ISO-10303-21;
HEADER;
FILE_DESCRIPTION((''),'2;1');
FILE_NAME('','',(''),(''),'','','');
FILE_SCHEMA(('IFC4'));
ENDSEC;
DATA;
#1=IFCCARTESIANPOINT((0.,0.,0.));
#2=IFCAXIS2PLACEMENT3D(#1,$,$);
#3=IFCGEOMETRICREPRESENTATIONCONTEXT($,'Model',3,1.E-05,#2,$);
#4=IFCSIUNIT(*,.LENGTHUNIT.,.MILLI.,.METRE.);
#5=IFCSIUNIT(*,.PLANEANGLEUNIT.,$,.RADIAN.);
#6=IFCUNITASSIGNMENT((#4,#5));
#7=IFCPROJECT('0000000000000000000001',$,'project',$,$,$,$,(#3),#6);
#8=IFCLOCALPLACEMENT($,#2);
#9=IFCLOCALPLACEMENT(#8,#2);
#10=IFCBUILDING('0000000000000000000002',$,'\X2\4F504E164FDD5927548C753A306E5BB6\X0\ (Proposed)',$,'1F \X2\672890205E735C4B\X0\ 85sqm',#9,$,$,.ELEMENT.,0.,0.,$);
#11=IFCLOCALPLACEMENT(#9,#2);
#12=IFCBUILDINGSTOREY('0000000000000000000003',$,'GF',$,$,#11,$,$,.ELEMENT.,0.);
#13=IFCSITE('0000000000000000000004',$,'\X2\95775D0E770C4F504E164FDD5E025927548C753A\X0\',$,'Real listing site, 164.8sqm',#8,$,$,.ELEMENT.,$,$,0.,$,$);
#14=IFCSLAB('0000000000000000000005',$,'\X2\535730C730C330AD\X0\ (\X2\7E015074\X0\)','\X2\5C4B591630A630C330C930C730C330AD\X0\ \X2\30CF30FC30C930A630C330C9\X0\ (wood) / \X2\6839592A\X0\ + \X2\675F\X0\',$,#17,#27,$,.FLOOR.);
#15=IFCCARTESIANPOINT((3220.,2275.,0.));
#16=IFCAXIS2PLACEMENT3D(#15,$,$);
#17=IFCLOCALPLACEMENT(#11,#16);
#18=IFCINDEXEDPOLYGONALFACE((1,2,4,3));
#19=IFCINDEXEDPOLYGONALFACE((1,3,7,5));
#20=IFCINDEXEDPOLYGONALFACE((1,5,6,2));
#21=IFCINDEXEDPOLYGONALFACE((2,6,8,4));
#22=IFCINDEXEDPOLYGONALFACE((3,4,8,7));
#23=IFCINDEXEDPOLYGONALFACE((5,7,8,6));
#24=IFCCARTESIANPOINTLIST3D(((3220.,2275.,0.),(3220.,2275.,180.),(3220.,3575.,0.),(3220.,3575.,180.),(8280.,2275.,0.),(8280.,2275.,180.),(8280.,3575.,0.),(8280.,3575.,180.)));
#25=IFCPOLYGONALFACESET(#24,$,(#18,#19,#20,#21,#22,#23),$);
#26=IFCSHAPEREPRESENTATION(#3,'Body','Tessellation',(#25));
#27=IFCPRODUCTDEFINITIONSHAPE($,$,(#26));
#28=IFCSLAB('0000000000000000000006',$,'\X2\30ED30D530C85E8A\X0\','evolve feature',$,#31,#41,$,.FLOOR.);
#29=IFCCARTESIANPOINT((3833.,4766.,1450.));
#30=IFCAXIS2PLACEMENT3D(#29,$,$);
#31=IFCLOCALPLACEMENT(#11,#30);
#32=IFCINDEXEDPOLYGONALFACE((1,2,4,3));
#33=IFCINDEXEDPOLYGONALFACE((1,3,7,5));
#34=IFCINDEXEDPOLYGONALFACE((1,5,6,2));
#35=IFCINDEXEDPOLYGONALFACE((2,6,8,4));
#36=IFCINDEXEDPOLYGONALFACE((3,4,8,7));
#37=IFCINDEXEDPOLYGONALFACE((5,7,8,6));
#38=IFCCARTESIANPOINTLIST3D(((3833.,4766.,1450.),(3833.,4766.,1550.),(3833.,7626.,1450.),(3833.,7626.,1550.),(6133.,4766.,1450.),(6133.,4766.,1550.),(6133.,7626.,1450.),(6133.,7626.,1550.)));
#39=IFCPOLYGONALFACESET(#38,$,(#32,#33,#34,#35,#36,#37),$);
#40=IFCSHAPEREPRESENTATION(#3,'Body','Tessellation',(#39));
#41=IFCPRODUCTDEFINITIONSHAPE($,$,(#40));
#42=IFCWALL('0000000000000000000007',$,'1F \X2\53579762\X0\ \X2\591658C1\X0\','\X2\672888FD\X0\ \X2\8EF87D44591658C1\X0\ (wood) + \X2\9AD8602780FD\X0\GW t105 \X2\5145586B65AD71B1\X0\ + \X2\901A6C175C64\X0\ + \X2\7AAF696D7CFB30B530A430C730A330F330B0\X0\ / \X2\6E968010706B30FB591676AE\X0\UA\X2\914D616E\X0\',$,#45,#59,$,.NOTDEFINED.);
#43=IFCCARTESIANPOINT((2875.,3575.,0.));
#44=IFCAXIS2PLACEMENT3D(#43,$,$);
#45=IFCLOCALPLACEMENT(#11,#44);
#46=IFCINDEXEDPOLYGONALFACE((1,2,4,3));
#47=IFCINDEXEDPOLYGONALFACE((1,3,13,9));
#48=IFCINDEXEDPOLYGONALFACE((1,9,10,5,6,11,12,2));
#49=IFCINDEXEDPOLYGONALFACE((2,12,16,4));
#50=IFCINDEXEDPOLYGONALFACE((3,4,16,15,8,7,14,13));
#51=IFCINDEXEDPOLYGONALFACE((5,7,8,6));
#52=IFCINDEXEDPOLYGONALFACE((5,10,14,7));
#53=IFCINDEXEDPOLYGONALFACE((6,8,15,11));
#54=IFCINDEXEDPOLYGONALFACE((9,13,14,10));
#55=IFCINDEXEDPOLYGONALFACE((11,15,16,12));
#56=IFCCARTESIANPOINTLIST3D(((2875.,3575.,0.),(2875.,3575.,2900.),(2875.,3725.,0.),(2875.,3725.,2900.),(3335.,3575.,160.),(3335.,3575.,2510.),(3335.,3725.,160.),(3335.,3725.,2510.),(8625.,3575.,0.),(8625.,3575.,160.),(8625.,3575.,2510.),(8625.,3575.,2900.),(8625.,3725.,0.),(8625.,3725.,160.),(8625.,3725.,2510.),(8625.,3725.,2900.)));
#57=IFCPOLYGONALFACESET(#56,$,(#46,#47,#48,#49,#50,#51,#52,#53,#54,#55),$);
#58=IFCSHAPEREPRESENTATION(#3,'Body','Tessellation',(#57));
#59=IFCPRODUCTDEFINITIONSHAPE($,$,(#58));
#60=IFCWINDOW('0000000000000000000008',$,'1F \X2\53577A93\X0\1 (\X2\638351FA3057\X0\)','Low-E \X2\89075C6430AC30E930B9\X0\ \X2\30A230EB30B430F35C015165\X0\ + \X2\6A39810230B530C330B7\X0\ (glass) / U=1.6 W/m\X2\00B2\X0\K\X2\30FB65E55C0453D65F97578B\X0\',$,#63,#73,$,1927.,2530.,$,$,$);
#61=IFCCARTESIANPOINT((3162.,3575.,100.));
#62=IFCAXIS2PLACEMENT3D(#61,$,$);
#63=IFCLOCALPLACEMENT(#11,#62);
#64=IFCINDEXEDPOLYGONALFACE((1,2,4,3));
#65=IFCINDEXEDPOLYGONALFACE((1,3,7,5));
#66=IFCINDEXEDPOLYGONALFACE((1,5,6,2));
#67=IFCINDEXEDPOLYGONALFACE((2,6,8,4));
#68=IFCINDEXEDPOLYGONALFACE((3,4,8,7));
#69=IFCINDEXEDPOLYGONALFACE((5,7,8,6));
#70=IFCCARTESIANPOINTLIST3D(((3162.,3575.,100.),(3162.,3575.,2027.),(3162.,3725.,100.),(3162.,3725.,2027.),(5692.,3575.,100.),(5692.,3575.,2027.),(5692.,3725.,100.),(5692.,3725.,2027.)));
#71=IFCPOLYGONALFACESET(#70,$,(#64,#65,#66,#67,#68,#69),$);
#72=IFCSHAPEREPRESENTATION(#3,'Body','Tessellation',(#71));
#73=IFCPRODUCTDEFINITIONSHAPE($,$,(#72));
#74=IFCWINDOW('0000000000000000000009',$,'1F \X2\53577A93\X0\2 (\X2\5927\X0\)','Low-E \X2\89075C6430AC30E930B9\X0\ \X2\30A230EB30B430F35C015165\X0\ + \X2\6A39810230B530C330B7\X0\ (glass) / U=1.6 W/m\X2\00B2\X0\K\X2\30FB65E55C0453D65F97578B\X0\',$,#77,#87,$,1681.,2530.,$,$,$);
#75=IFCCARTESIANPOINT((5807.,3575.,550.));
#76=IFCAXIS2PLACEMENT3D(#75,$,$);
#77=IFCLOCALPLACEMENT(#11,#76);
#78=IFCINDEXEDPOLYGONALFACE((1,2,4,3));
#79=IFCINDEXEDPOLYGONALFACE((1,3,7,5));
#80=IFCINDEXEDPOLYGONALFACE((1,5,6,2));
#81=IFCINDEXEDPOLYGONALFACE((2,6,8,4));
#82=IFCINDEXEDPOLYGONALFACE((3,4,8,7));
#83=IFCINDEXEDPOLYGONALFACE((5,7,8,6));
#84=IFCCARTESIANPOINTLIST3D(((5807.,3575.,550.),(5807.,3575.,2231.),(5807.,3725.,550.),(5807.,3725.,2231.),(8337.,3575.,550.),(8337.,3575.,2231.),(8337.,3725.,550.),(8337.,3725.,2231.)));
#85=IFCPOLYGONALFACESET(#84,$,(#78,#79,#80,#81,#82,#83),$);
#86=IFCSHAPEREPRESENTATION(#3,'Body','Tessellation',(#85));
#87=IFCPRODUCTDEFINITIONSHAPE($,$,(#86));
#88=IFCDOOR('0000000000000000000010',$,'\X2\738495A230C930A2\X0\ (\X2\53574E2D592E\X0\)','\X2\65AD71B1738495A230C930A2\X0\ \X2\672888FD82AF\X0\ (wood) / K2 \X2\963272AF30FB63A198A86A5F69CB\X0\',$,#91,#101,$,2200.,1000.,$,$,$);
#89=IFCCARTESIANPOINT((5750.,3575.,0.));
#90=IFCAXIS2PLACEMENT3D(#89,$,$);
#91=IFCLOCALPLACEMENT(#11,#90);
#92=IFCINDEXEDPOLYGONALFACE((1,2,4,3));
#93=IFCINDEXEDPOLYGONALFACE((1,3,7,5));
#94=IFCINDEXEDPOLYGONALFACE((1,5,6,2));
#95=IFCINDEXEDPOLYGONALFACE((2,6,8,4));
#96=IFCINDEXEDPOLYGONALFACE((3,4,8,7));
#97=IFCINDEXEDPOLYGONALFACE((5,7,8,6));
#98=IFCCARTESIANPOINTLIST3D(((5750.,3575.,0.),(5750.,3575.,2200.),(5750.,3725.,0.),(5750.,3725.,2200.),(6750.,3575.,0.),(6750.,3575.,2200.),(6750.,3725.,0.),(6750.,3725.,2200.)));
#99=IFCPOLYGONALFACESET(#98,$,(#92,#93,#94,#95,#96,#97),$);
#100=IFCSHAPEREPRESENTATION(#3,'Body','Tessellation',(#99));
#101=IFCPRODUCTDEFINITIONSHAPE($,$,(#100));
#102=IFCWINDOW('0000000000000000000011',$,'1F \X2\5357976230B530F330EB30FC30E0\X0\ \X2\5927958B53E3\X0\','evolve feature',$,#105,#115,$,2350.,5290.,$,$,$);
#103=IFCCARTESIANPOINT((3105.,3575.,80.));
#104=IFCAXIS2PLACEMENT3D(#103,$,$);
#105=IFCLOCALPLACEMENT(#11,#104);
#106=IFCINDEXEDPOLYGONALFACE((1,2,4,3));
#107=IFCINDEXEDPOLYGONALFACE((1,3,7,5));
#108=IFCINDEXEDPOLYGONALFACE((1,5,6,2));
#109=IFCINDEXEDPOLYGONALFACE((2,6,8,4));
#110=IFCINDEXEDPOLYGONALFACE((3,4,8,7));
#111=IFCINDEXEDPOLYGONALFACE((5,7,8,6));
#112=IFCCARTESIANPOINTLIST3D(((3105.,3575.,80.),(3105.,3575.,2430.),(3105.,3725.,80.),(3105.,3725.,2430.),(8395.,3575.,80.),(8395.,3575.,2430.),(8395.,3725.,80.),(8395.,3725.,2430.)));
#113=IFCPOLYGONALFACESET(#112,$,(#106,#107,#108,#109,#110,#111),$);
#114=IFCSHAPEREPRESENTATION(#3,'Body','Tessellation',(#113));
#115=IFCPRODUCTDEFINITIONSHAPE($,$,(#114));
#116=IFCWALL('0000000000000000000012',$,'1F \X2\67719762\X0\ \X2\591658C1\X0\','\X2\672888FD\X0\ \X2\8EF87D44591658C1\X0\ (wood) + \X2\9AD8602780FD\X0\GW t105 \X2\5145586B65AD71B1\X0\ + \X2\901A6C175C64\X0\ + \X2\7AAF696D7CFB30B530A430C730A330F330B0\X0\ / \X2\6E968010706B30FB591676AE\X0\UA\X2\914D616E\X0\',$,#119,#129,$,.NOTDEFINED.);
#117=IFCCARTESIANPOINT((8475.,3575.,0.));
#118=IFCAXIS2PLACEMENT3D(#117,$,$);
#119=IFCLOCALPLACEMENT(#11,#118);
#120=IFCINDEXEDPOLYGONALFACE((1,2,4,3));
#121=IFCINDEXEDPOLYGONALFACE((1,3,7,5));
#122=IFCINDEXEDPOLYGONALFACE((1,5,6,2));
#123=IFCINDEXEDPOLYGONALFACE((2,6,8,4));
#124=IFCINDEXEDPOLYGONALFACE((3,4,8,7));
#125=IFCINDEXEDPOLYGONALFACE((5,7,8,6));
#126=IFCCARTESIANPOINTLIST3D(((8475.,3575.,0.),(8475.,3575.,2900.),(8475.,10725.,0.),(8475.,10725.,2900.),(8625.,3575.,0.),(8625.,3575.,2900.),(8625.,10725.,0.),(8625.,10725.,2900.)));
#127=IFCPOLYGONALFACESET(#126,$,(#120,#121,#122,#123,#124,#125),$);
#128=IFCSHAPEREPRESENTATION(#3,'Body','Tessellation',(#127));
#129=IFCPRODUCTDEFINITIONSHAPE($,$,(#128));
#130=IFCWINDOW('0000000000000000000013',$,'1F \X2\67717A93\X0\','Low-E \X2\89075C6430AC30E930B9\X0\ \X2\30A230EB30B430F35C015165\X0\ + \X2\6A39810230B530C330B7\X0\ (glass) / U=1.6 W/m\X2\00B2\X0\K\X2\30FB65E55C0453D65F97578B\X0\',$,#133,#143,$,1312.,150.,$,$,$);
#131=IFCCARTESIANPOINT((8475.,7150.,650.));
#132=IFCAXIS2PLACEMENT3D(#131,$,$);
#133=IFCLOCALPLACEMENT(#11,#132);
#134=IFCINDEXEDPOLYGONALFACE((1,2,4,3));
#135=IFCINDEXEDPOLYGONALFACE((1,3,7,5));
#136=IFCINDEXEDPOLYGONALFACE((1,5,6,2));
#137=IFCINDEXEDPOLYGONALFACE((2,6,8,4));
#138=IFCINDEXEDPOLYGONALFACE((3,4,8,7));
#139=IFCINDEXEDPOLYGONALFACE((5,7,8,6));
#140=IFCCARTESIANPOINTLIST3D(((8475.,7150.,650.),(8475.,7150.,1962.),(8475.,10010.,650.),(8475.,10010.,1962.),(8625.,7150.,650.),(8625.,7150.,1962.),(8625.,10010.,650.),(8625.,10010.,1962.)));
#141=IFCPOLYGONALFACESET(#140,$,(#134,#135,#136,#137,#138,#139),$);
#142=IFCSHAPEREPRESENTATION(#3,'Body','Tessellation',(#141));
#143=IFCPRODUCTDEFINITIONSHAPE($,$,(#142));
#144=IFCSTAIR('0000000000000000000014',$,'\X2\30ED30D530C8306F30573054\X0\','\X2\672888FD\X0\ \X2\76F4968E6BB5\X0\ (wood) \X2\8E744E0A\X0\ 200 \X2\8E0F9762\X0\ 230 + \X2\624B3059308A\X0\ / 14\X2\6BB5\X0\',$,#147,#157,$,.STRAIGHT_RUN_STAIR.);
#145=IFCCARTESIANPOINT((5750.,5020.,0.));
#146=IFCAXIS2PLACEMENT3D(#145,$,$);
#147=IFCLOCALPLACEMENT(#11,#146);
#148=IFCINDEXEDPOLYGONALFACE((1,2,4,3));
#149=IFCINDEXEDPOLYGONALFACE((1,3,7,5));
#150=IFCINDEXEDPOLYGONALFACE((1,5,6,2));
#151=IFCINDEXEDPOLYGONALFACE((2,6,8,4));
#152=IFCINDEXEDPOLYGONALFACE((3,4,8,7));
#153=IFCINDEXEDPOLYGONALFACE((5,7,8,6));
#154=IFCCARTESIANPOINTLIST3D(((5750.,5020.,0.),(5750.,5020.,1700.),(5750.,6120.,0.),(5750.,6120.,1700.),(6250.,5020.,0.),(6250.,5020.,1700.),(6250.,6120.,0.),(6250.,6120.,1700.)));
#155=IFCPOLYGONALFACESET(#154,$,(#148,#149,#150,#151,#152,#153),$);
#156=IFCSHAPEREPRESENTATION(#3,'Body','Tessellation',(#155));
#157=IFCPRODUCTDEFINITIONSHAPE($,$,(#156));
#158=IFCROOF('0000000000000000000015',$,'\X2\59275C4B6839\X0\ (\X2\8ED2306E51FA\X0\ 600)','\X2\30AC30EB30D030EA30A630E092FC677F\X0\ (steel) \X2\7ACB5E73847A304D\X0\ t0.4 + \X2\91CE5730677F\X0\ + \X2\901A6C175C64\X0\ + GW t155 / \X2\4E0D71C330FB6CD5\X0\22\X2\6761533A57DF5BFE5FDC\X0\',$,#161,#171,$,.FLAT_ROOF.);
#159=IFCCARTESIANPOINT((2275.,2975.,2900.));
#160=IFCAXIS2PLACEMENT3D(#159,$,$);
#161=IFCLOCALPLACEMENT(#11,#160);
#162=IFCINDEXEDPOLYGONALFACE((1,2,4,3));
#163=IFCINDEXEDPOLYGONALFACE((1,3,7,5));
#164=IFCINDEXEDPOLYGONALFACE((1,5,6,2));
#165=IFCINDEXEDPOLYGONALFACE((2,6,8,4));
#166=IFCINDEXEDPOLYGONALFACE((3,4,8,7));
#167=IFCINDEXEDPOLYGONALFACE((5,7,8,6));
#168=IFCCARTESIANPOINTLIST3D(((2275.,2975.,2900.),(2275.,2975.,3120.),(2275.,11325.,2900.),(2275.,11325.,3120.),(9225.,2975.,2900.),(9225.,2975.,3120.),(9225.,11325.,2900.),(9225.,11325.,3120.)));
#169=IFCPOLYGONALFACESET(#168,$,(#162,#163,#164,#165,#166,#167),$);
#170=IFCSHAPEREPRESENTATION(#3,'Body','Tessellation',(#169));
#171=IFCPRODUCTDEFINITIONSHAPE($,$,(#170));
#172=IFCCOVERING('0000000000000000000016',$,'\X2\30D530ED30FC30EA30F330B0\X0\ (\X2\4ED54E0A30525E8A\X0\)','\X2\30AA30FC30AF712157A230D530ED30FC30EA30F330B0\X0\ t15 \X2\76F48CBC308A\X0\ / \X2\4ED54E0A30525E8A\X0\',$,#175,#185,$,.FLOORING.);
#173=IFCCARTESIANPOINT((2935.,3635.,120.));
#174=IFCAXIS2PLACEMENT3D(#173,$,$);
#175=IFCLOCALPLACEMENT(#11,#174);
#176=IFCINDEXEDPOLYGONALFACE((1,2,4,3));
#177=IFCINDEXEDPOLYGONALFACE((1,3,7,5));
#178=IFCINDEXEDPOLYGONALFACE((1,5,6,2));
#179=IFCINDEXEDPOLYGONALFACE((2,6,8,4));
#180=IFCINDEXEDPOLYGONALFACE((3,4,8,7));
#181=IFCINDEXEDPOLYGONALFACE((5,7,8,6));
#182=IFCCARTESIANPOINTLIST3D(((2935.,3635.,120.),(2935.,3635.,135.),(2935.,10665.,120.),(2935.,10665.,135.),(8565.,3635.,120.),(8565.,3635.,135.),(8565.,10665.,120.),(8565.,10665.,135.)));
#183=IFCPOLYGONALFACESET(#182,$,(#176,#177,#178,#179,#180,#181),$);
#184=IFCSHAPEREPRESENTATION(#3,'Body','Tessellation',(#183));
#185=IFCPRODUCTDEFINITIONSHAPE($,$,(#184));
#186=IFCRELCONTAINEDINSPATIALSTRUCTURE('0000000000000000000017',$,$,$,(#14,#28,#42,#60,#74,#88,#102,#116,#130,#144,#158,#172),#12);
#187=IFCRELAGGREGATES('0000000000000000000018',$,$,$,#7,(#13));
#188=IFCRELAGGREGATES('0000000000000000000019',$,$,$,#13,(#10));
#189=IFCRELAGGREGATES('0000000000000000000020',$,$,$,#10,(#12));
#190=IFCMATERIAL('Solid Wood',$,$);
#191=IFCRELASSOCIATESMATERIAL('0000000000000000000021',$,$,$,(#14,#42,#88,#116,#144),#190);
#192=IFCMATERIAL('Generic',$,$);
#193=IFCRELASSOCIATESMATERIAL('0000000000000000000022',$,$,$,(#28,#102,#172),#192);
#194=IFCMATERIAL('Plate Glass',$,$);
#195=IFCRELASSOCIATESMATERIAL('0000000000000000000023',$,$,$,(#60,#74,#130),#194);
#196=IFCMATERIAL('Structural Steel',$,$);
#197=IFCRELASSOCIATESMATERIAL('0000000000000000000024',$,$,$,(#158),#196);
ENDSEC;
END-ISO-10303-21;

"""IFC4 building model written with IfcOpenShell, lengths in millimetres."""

from ifc_helpers import new_model, si_unit, frame, frame_2d, origin, place, context, project, spatial, rectangle, extrude, material, element, fill, save


model = new_model("IFC4")

# Units and contexts
model_context = context("Model", 3, precision=1e-05, world=origin())
ifc_project = project(units=[si_unit("LENGTHUNIT", "METRE", prefix="MILLI"), si_unit("PLANEANGLEUNIT", "RADIAN")], contexts=[model_context])

# Site, building, storey
site_placement = place(None, origin())
site = spatial("IfcSite", under=ifc_project, at=site_placement, Name="長崎県佐世保市大和町", ObjectType="Real listing site, 164.8sqm", CompositionType="ELEMENT", RefElevation=0.0)
building_placement = place(site_placement, origin())
building = spatial("IfcBuilding", under=site, at=building_placement, Name="佐世保大和町の家 (Proposed)", ObjectType="1F 木造平屋 85sqm", CompositionType="ELEMENT", ElevationOfRefHeight=0.0, ElevationOfTerrain=0.0)
storey_placement = place(building_placement, origin())
storey = spatial("IfcBuildingStorey", under=building, at=storey_placement, Name="GF", CompositionType="ELEMENT", Elevation=0.0)

# Slabs
ifc_material_1 = material(Name="Solid Wood")
slab_1_placement = place(storey_placement, frame((3220.0, 2275.0, 0.0)))
element("IfcSlab", 1, at=slab_1_placement, inside=storey, material=ifc_material_1, Name="南デッキ (縁側)", Description="屋外ウッドデッキ ハードウッド (wood) / 根太 + 束", PredefinedType="FLOOR", context=model_context, shape_type="SweptSolid", body=[
    extrude(rectangle(XDim=5060.0, YDim=1300.0, at=frame_2d((2530.0, 650.0))), frame((3220.0, 2275.0, 0.0)), (0.0, 0.0, 1.0), 180.0),
])
ifc_material_2 = material(Name="Generic")
slab_2_placement = place(storey_placement, frame((3833.0, 4766.0, 1450.0)))
element("IfcSlab", 2, at=slab_2_placement, inside=storey, material=ifc_material_2, Name="ロフト床", Description="evolve feature", PredefinedType="FLOOR", context=model_context, shape_type="SweptSolid", body=[
    extrude(rectangle(XDim=2300.0, YDim=2860.0, at=frame_2d((1150.0, 1430.0))), frame((3833.0, 4766.0, 1450.0)), (0.0, 0.0, 1.0), 100.0),
])

# Wall, openings, windows, door
wall_1_placement = place(storey_placement, frame((2875.0, 3575.0, 0.0)))
wall_1 = element("IfcWall", 3, at=wall_1_placement, inside=storey, material=ifc_material_1, Name="1F 南面 外壁", Description="木製 軸組外壁 (wood) + 高性能GW t105 充填断熱 + 通気層 + 窯業系サイディング / 準耐火・外皮UA配慮", PredefinedType="NOTDEFINED", context=model_context, shape_type="SweptSolid", body=[
    extrude(rectangle(XDim=5750.0, YDim=150.0, at=frame_2d((2875.0, 75.0))), frame((2875.0, 3575.0, 0.0)), (0.0, 0.0, 1.0), 2900.0),
])
opening_1_placement = place(storey_placement, frame((3162.0, 3575.0, 100.0)))
opening_1 = element("IfcOpeningElement", 4, at=opening_1_placement, cuts=wall_1, PredefinedType="NOTDEFINED", context=model_context, shape_type="SweptSolid", body=[
    extrude(rectangle(XDim=2530.0, YDim=150.0, at=frame_2d((1265.0, 75.0))), frame((3162.0, 3575.0, 100.0)), (0.0, 0.0, 1.0), 1927.0),
])
opening_2_placement = place(storey_placement, frame((5807.0, 3575.0, 550.0)))
opening_2 = element("IfcOpeningElement", 5, at=opening_2_placement, cuts=wall_1, PredefinedType="NOTDEFINED", context=model_context, shape_type="SweptSolid", body=[
    extrude(rectangle(XDim=2530.0, YDim=150.0, at=frame_2d((1265.0, 75.0))), frame((5807.0, 3575.0, 550.0)), (0.0, 0.0, 1.0), 1681.0),
])
opening_3_placement = place(storey_placement, frame((5750.0, 3575.0, 0.0)))
opening_3 = element("IfcOpeningElement", 6, at=opening_3_placement, cuts=wall_1, PredefinedType="NOTDEFINED", context=model_context, shape_type="SweptSolid", body=[
    extrude(rectangle(XDim=1000.0, YDim=150.0, at=frame_2d((500.0, 75.0))), frame((5750.0, 3575.0, 0.0)), (0.0, 0.0, 1.0), 2200.0),
])
opening_4_placement = place(storey_placement, frame((3105.0, 3575.0, 80.0)))
opening_4 = element("IfcOpeningElement", 7, at=opening_4_placement, cuts=wall_1, PredefinedType="NOTDEFINED", context=model_context, shape_type="SweptSolid", body=[
    extrude(rectangle(XDim=5290.0, YDim=150.0, at=frame_2d((2645.0, 75.0))), frame((3105.0, 3575.0, 80.0)), (0.0, 0.0, 1.0), 2350.0),
])
ifc_material_3 = material(Name="Plate Glass")
window_1_placement = place(storey_placement, frame((3162.0, 3575.0, 100.0)))
window_1 = element("IfcWindow", 8, at=window_1_placement, inside=storey, material=ifc_material_3, Name="1F 南窓1 (掃出し)", Description="Low-E 複層ガラス アルゴン封入 + 樹脂サッシ (glass) / U=1.6 W/m²K・日射取得型", OverallHeight=1927.0, OverallWidth=2530.0, context=model_context, shape_type="SweptSolid", body=[
    extrude(rectangle(XDim=2530.0, YDim=150.0, at=frame_2d((1265.0, 75.0))), frame((3162.0, 3575.0, 100.0)), (0.0, 0.0, 1.0), 1927.0),
])
fill(opening_1, window_1)
window_2_placement = place(storey_placement, frame((5807.0, 3575.0, 550.0)))
window_2 = element("IfcWindow", 9, at=window_2_placement, inside=storey, material=ifc_material_3, Name="1F 南窓2 (大)", Description="Low-E 複層ガラス アルゴン封入 + 樹脂サッシ (glass) / U=1.6 W/m²K・日射取得型", OverallHeight=1681.0, OverallWidth=2530.0, context=model_context, shape_type="SweptSolid", body=[
    extrude(rectangle(XDim=2530.0, YDim=150.0, at=frame_2d((1265.0, 75.0))), frame((5807.0, 3575.0, 550.0)), (0.0, 0.0, 1.0), 1681.0),
])
fill(opening_2, window_2)
door_placement = place(storey_placement, frame((5750.0, 3575.0, 0.0)))
door = element("IfcDoor", 10, at=door_placement, inside=storey, material=ifc_material_1, Name="玄関ドア (南中央)", Description="断熱玄関ドア 木製芯 (wood) / K2 防犯・採風機構", OverallHeight=2200.0, OverallWidth=1000.0, context=model_context, shape_type="SweptSolid", body=[
    extrude(rectangle(XDim=1000.0, YDim=150.0, at=frame_2d((500.0, 75.0))), frame((5750.0, 3575.0, 0.0)), (0.0, 0.0, 1.0), 2200.0),
])
fill(opening_3, door)
window_3_placement = place(storey_placement, frame((3105.0, 3575.0, 80.0)))
window_3 = element("IfcWindow", 11, at=window_3_placement, inside=storey, material=ifc_material_2, Name="1F 南面サンルーム 大開口", Description="evolve feature", OverallHeight=2350.0, OverallWidth=5290.0, context=model_context, shape_type="SweptSolid", body=[
    extrude(rectangle(XDim=5290.0, YDim=150.0, at=frame_2d((2645.0, 75.0))), frame((3105.0, 3575.0, 80.0)), (0.0, 0.0, 1.0), 2350.0),
])
fill(opening_4, window_3)

# Wall, opening, window
wall_2_placement = place(storey_placement, frame((8475.0, 3575.0, 0.0)))
wall_2 = element("IfcWall", 12, at=wall_2_placement, inside=storey, material=ifc_material_1, Name="1F 東面 外壁", Description="木製 軸組外壁 (wood) + 高性能GW t105 充填断熱 + 通気層 + 窯業系サイディング / 準耐火・外皮UA配慮", PredefinedType="NOTDEFINED", context=model_context, shape_type="SweptSolid", body=[
    extrude(rectangle(XDim=150.0, YDim=7150.0, at=frame_2d((75.0, 3575.0))), frame((8475.0, 3575.0, 0.0)), (0.0, 0.0, 1.0), 2900.0),
])
opening_5_placement = place(storey_placement, frame((8475.0, 7150.0, 650.0)))
opening_5 = element("IfcOpeningElement", 13, at=opening_5_placement, cuts=wall_2, PredefinedType="NOTDEFINED", context=model_context, shape_type="SweptSolid", body=[
    extrude(rectangle(XDim=150.0, YDim=2860.0, at=frame_2d((75.0, 1430.0))), frame((8475.0, 7150.0, 650.0)), (0.0, 0.0, 1.0), 1312.0),
])
window_4_placement = place(storey_placement, frame((8475.0, 7150.0, 650.0)))
window_4 = element("IfcWindow", 14, at=window_4_placement, inside=storey, material=ifc_material_3, Name="1F 東窓", Description="Low-E 複層ガラス アルゴン封入 + 樹脂サッシ (glass) / U=1.6 W/m²K・日射取得型", OverallHeight=1312.0, OverallWidth=150.0, context=model_context, shape_type="SweptSolid", body=[
    extrude(rectangle(XDim=150.0, YDim=2860.0, at=frame_2d((75.0, 1430.0))), frame((8475.0, 7150.0, 650.0)), (0.0, 0.0, 1.0), 1312.0),
])
fill(opening_5, window_4)

# Stair
stair_placement = place(storey_placement, frame((5750.0, 5020.0, 0.0)))
element("IfcStair", 15, at=stair_placement, inside=storey, material=ifc_material_1, Name="ロフトはしご", Description="木製 直階段 (wood) 蹴上 200 踏面 230 + 手すり / 14段", PredefinedType="STRAIGHT_RUN_STAIR", context=model_context, shape_type="SweptSolid", body=[
    extrude(rectangle(XDim=500.0, YDim=1100.0, at=frame_2d((250.0, 550.0))), frame((5750.0, 5020.0, 0.0)), (0.0, 0.0, 1.0), 1700.0),
])

# Roof
ifc_material_4 = material(Name="Structural Steel")
roof_placement = place(storey_placement, frame((2275.0, 2975.0, 2900.0)))
element("IfcRoof", 16, at=roof_placement, inside=storey, material=ifc_material_4, Name="大屋根 (軒の出 600)", Description="ガルバリウム鋼板 (steel) 立平葺き t0.4 + 野地板 + 通気層 + GW t155 / 不燃・法22条区域対応", PredefinedType="FLAT_ROOF", context=model_context, shape_type="SweptSolid", body=[
    extrude(rectangle(XDim=6950.0, YDim=8350.0, at=frame_2d((3475.0, 4175.0))), frame((2275.0, 2975.0, 2900.0)), (0.0, 0.0, 1.0), 220.0),
])

# Covering
covering_placement = place(storey_placement, frame((2935.0, 3635.0, 120.0)))
element("IfcCovering", 17, at=covering_placement, inside=storey, material=ifc_material_2, Name="フローリング (仕上げ床)", Description="オーク無垢フローリング t15 直貼り / 仕上げ床", PredefinedType="FLOORING", context=model_context, shape_type="SweptSolid", body=[
    extrude(rectangle(XDim=5630.0, YDim=7030.0, at=frame_2d((2815.0, 3515.0))), frame((2935.0, 3635.0, 120.0)), (0.0, 0.0, 1.0), 15.0),
])

save(model, "model.ifc")
